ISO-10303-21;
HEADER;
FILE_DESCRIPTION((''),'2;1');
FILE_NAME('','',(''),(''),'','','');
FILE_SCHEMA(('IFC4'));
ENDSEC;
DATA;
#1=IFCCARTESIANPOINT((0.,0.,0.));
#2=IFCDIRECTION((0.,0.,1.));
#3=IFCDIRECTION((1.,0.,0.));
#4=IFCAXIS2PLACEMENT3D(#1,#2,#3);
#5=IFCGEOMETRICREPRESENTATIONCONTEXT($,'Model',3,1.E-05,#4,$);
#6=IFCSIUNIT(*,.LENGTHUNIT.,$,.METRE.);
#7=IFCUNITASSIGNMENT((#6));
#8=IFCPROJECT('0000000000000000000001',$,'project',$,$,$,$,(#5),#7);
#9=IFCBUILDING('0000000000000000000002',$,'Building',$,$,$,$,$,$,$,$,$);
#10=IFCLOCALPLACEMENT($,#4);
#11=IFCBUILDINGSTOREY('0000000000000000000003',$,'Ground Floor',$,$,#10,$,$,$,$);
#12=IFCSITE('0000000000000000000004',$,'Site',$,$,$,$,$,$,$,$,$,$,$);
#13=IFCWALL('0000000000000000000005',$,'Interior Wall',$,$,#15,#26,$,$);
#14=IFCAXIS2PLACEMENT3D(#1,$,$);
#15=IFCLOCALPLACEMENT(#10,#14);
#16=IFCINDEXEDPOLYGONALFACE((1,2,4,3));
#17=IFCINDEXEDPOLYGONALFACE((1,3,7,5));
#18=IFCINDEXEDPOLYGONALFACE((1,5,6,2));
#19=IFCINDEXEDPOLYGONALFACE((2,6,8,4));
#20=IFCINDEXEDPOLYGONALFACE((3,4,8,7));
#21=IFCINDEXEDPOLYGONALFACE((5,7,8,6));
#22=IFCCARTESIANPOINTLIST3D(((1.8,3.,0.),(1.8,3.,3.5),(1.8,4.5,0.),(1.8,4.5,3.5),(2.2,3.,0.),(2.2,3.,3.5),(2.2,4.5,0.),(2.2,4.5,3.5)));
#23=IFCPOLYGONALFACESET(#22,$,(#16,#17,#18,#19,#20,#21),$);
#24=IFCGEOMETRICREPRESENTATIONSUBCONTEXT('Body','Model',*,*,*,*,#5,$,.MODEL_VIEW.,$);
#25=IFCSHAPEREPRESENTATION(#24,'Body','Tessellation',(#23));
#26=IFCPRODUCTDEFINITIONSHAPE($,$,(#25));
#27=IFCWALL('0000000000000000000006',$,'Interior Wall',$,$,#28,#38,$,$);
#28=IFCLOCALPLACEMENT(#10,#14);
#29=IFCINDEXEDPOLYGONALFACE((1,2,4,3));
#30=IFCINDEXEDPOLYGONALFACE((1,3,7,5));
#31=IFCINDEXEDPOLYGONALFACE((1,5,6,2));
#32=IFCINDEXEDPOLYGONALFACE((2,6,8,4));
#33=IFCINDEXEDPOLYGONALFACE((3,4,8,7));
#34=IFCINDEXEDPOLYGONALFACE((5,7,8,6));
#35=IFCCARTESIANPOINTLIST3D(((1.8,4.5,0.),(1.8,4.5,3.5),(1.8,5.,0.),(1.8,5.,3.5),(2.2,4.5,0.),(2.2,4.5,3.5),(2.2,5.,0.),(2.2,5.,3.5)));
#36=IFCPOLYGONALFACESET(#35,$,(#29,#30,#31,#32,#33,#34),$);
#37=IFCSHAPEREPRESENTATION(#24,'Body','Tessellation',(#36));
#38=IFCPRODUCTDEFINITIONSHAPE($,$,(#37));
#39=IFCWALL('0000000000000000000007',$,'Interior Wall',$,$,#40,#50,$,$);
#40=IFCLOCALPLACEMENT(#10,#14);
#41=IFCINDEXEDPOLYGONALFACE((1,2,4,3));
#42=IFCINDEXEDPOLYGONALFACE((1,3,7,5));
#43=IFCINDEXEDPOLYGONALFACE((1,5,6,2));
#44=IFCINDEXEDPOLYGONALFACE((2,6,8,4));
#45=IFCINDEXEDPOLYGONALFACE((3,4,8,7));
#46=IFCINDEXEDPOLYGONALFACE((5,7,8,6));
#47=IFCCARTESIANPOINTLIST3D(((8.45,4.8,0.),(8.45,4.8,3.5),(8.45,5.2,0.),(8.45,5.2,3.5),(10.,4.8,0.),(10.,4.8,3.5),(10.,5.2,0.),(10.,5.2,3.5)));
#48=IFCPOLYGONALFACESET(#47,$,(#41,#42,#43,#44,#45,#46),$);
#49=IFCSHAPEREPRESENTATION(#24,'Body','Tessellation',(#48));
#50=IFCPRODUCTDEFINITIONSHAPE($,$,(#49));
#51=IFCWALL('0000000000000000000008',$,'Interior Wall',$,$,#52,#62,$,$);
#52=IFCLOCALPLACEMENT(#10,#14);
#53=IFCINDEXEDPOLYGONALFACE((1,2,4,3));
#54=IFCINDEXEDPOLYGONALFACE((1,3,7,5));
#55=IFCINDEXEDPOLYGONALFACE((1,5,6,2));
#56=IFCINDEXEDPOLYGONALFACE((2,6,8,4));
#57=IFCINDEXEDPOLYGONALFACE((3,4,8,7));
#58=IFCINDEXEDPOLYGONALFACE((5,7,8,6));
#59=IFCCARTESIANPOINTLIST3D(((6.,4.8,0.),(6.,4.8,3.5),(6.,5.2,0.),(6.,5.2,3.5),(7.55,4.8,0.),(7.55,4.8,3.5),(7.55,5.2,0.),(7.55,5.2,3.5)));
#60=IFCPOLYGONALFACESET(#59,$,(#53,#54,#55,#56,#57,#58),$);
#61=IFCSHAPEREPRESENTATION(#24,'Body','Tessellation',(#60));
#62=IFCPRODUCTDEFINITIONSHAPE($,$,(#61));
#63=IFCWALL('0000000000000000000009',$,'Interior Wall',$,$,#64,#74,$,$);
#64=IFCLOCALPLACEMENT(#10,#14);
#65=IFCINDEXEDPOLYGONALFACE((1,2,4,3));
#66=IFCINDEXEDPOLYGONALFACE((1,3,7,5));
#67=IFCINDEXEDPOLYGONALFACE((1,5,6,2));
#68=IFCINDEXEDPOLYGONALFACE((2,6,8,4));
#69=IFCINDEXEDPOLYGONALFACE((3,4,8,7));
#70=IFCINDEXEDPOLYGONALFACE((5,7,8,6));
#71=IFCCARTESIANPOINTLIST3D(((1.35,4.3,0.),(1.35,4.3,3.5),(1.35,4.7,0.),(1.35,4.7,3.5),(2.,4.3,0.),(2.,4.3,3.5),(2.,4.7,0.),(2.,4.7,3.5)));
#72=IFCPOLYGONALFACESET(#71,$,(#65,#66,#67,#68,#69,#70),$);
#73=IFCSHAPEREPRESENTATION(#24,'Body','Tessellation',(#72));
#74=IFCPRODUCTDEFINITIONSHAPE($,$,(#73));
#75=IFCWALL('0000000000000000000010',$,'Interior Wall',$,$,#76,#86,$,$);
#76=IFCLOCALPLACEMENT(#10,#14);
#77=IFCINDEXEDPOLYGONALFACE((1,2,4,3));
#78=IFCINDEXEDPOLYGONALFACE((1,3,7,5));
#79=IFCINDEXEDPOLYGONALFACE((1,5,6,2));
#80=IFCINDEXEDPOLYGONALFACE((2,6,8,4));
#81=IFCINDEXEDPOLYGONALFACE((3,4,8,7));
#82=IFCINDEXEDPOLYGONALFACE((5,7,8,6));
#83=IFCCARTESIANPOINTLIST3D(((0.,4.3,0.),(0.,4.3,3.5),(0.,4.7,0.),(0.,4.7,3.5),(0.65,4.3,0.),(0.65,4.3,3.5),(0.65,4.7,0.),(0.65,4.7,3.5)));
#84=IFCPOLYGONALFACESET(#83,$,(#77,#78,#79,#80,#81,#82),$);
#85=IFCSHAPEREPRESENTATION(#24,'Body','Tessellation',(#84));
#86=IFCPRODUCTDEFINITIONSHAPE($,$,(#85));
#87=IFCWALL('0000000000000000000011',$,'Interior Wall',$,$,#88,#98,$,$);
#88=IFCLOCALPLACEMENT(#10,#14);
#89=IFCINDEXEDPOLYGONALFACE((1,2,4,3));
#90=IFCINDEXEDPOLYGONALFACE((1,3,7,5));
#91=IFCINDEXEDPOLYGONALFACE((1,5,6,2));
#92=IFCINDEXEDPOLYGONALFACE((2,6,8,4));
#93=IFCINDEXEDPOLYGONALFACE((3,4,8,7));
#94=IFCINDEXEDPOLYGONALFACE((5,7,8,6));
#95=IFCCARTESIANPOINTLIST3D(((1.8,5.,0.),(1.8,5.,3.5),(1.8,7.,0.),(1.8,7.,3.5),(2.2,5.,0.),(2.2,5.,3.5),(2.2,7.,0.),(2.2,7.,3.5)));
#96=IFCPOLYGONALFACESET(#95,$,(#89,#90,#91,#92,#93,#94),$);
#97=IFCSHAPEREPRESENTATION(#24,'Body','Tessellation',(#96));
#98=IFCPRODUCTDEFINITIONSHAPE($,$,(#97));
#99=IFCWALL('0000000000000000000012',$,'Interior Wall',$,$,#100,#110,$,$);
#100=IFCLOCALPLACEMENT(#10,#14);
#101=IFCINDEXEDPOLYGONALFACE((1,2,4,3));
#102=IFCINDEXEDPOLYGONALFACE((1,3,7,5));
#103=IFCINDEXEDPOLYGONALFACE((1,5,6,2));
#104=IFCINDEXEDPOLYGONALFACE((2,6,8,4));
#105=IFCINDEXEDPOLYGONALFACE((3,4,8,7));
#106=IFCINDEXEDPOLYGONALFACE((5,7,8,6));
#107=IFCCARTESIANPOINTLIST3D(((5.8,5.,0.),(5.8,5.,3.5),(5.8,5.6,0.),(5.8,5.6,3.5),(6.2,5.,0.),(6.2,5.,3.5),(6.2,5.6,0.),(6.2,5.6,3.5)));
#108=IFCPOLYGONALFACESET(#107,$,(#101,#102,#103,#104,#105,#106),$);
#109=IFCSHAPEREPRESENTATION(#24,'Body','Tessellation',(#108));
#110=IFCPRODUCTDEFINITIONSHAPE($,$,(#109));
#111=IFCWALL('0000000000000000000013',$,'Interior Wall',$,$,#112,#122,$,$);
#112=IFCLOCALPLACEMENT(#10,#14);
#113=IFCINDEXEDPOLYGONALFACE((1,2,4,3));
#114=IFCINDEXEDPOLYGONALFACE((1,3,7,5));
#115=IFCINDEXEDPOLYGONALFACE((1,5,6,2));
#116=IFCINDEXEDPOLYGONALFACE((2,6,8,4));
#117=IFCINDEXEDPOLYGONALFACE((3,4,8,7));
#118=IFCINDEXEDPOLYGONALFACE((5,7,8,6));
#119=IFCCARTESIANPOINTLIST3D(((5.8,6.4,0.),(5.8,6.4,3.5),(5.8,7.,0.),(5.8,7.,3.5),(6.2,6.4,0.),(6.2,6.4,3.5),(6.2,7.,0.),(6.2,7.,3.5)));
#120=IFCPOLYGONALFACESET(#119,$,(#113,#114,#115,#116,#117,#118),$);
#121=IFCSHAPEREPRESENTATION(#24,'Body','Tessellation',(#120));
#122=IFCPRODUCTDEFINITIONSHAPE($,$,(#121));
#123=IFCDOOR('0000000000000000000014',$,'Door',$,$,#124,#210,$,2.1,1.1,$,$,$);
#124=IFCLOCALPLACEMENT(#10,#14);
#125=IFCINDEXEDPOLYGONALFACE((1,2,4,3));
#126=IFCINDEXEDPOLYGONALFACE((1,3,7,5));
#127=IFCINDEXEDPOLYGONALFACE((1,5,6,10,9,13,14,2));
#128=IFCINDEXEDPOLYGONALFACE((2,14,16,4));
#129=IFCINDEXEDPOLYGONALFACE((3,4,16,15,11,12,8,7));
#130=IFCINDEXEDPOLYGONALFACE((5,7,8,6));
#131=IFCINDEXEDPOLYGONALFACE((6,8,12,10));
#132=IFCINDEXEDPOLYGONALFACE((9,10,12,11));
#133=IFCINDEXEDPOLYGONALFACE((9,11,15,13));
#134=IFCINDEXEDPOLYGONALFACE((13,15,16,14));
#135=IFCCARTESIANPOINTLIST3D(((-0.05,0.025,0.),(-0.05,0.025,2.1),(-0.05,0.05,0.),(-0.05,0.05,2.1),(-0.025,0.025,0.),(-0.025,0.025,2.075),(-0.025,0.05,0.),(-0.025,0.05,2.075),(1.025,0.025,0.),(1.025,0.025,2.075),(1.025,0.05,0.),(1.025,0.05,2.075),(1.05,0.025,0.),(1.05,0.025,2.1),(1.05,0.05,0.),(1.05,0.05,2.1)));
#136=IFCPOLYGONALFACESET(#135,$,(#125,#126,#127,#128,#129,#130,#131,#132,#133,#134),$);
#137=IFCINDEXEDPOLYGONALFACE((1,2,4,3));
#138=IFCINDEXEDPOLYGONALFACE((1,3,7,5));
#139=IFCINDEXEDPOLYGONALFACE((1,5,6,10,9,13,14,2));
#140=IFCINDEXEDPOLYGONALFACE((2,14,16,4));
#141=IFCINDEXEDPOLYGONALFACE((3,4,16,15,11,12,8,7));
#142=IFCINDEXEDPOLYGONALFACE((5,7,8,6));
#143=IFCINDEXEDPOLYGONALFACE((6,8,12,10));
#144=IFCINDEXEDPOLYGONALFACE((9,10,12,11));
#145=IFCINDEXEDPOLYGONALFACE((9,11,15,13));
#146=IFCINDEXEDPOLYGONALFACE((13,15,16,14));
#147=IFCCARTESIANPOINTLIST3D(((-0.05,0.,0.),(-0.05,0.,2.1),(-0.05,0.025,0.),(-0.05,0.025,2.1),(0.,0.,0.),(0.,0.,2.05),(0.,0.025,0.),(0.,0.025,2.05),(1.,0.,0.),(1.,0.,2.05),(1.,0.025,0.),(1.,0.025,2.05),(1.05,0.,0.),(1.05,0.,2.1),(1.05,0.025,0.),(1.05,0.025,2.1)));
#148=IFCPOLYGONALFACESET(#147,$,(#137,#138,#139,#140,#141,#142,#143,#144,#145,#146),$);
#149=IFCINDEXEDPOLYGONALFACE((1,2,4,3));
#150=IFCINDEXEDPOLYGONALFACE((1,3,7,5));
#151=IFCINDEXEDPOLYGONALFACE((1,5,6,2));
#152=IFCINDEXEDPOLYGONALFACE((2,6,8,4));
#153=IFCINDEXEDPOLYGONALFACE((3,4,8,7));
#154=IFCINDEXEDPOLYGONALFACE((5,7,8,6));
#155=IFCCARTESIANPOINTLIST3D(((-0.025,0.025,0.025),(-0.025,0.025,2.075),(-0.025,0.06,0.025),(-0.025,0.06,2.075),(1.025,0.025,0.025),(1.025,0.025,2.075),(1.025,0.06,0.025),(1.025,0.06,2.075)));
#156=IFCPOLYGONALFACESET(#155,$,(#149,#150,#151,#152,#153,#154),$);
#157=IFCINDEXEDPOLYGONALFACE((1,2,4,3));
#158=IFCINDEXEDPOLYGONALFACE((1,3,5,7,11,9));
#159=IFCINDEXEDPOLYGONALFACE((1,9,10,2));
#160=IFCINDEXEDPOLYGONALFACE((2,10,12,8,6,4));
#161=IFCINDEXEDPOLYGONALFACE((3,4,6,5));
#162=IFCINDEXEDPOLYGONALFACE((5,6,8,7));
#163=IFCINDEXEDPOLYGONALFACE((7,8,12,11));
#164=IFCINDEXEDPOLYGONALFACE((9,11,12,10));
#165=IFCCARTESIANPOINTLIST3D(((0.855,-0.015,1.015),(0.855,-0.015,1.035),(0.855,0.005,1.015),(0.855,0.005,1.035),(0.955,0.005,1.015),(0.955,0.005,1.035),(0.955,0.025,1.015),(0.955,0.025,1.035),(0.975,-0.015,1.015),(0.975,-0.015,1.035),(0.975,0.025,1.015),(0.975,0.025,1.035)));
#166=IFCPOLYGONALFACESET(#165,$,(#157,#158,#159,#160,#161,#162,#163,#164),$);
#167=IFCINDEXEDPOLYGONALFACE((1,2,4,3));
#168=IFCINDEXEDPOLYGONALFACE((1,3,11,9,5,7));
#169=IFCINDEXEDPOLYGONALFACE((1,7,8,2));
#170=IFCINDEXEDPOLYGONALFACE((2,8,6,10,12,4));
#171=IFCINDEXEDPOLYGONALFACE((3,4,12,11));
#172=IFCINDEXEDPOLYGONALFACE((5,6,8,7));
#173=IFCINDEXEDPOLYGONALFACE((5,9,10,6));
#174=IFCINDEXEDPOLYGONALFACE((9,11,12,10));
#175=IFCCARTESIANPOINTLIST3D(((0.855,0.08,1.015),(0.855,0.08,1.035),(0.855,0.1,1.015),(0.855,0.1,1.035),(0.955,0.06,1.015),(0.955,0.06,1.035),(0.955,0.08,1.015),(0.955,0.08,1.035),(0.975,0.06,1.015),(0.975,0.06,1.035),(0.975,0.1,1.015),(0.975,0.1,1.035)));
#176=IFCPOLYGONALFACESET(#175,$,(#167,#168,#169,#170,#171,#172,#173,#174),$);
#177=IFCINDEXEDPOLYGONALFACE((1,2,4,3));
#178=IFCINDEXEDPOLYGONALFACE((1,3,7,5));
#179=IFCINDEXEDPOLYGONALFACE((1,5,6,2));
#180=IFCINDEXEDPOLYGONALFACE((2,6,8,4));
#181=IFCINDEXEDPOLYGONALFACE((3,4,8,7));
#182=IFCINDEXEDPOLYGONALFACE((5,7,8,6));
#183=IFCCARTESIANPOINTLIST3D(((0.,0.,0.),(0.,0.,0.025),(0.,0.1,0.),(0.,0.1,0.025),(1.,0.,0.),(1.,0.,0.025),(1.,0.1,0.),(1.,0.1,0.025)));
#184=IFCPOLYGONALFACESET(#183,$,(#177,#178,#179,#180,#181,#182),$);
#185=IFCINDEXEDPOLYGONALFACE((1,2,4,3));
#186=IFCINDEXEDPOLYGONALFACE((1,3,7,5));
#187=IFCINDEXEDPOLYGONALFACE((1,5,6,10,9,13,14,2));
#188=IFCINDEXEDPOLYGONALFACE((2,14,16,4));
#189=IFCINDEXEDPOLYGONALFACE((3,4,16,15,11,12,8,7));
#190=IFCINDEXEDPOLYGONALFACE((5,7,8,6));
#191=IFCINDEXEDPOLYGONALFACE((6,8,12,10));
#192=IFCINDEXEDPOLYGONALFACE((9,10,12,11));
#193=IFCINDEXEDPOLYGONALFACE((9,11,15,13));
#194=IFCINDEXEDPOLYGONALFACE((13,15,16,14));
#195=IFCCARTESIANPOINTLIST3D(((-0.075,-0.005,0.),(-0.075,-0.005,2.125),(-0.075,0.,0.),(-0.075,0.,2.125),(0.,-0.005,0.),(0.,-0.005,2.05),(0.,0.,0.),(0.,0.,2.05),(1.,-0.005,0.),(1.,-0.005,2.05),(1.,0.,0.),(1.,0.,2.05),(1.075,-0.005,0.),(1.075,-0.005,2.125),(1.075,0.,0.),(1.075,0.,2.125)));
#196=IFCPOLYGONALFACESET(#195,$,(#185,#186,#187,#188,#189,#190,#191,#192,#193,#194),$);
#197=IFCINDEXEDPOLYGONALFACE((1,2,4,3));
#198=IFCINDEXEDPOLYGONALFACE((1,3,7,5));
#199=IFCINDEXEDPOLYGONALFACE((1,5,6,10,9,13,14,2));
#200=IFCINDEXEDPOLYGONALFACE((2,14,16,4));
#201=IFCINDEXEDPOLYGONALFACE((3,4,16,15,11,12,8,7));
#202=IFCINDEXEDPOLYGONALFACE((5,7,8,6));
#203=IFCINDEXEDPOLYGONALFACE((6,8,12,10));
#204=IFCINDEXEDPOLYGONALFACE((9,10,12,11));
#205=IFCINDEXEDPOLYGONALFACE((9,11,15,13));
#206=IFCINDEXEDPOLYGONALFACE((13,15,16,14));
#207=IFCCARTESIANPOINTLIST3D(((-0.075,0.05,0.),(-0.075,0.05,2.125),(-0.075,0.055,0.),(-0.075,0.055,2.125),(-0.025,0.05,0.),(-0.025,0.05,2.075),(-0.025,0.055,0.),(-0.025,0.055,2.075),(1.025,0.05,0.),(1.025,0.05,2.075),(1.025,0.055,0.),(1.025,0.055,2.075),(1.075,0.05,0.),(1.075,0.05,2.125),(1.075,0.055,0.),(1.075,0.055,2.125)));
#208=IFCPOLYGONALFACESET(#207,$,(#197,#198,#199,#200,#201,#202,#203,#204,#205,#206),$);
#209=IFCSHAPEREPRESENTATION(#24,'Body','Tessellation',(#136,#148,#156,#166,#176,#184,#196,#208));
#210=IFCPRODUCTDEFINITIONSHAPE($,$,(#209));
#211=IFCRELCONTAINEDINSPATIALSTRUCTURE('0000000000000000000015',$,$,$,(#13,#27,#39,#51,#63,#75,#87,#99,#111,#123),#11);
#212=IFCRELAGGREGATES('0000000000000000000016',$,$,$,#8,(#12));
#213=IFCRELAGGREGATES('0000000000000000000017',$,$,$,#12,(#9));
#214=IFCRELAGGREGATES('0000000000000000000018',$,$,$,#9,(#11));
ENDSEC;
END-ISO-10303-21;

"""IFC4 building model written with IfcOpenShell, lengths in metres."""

from ifc_helpers import new_model, si_unit, frame, origin_with_axes, place, context, subcontext, project, spatial, line, indexed_curve, outline, extrude, element, save


model = new_model("IFC4")

# Units and contexts
model_context = context("Model", 3, precision=1e-05, world=origin_with_axes())
body_context = subcontext(model_context, "Body", "Model", "MODEL_VIEW")
ifc_project = project(units=[si_unit("LENGTHUNIT", "METRE")], contexts=[model_context])

# Site, building, storey
site = spatial("IfcSite", under=ifc_project, Name="Site")
building = spatial("IfcBuilding", under=site, Name="Building")
storey_placement = place(None, origin_with_axes())
storey = spatial("IfcBuildingStorey", under=building, at=storey_placement, Name="Ground Floor")

# Walls
wall_1_placement = place(storey_placement, frame((2.0, 4.5, 0.0), z_axis=(0.0, 0.0, 1.0), x_axis=(0.0, -1.0, 0.0)))
element("IfcWall", 1, at=wall_1_placement, inside=storey, Name="Interior Wall", context=body_context, shape_type="SweptSolid", body=[
    extrude(outline(indexed_curve([(0.0, 0.0), (0.0, 0.4), (1.5, 0.4), (1.5, 0.0), (0.0, 0.0)], self_intersect=False)), frame((0.0, -0.2, 0.0), z_axis=(0.0, 0.0, 1.0), x_axis=(1.0, 0.0, 0.0)), (0.0, 0.0, 1.0), 3.5),
])
wall_2_placement = place(storey_placement, frame((2.0, 5.0, 0.0), z_axis=(0.0, 0.0, 1.0), x_axis=(0.0, -1.0, 0.0)))
element("IfcWall", 2, at=wall_2_placement, inside=storey, Name="Interior Wall", context=body_context, shape_type="SweptSolid", body=[
    extrude(outline(indexed_curve([(0.0, 0.0), (0.0, 0.4), (0.5, 0.4), (0.5, 0.0), (0.0, 0.0)], self_intersect=False)), frame((0.0, -0.2, 0.0), z_axis=(0.0, 0.0, 1.0), x_axis=(1.0, 0.0, 0.0)), (0.0, 0.0, 1.0), 3.5),
])
wall_3_placement = place(storey_placement, frame((10.0, 5.0, 0.0), z_axis=(0.0, 0.0, 1.0), x_axis=(-1.0, 0.0, 0.0)))
element("IfcWall", 3, at=wall_3_placement, inside=storey, Name="Interior Wall", context=body_context, shape_type="SweptSolid", body=[
    extrude(outline(indexed_curve([(0.0, 0.0), (0.0, 0.4), (1.55, 0.4), (1.55, 0.0), (0.0, 0.0)], self_intersect=False)), frame((0.0, -0.2, 0.0), z_axis=(0.0, 0.0, 1.0), x_axis=(1.0, 0.0, 0.0)), (0.0, 0.0, 1.0), 3.5),
])
wall_4_placement = place(storey_placement, frame((7.55, 5.0, 0.0), z_axis=(0.0, 0.0, 1.0), x_axis=(-1.0, 0.0, 0.0)))
element("IfcWall", 4, at=wall_4_placement, inside=storey, Name="Interior Wall", context=body_context, shape_type="SweptSolid", body=[
    extrude(outline(indexed_curve([(0.0, 0.0), (0.0, 0.4), (1.55, 0.4), (1.55, 0.0), (0.0, 0.0)], self_intersect=False)), frame((0.0, -0.2, 0.0), z_axis=(0.0, 0.0, 1.0), x_axis=(1.0, 0.0, 0.0)), (0.0, 0.0, 1.0), 3.5),
])
for number, where, z_axis, x_axis, name in (
    (5, (2.0, 4.5, 0.0), (0.0, 0.0, 1.0), (-1.0, 0.0, 0.0), "Interior Wall"),
    (6, (0.65, 4.5, 0.0), (0.0, 0.0, 1.0), (-1.0, 0.0, 0.0), "Interior Wall"),
):
    element("IfcWall", number, at=place(storey_placement, frame(where, z_axis=z_axis, x_axis=x_axis)), inside=storey, Name=name, context=body_context, shape_type="SweptSolid", body=[
        extrude(outline(indexed_curve([(0.0, 0.0), (0.0, 0.4), (0.65, 0.4), (0.65, 0.0), (0.0, 0.0)], self_intersect=False)), frame((0.0, -0.2, 0.0), z_axis=(0.0, 0.0, 1.0), x_axis=(1.0, 0.0, 0.0)), (0.0, 0.0, 1.0), 3.5),
    ])
wall_5_placement = place(storey_placement, frame((2.0, 5.0, 0.0), z_axis=(0.0, 0.0, 1.0), x_axis=(0.0, 1.0, 0.0)))
element("IfcWall", 7, at=wall_5_placement, inside=storey, Name="Interior Wall", context=body_context, shape_type="SweptSolid", body=[
    extrude(outline(indexed_curve([(0.0, 0.0), (0.0, 0.4), (2.0, 0.4), (2.0, 0.0), (0.0, 0.0)], self_intersect=False)), frame((0.0, -0.2, 0.0), z_axis=(0.0, 0.0, 1.0), x_axis=(1.0, 0.0, 0.0)), (0.0, 0.0, 1.0), 3.5),
])
for number, where, z_axis, x_axis, name in (
    (8, (6.0, 5.0, 0.0), (0.0, 0.0, 1.0), (0.0, 1.0, 0.0), "Interior Wall"),
    (9, (6.0, 6.4, 0.0), (0.0, 0.0, 1.0), (0.0, 1.0, 0.0), "Interior Wall"),
):
    element("IfcWall", number, at=place(storey_placement, frame(where, z_axis=z_axis, x_axis=x_axis)), inside=storey, Name=name, context=body_context, shape_type="SweptSolid", body=[
        extrude(outline(indexed_curve([(0.0, 0.0), (0.0, 0.4), (0.6, 0.4), (0.6, 0.0), (0.0, 0.0)], self_intersect=False)), frame((0.0, -0.2, 0.0), z_axis=(0.0, 0.0, 1.0), x_axis=(1.0, 0.0, 0.0)), (0.0, 0.0, 1.0), 3.5),
    ])

# Door
door_1_placement = place(storey_placement, frame((-0.05, 0.0, 0.0), z_axis=(0.0, 0.0, 1.0), x_axis=(1.0, 0.0, 0.0)))
element("IfcDoor", 10, at=door_1_placement, inside=storey, Name="Door", OverallHeight=2.1, OverallWidth=1.1, context=body_context, shape_type="SweptSolid", body=[
    extrude(outline(indexed_curve([(0.0, 0.0), (0.0, 2.1), (1.1, 2.1), (1.1, 0.0), (1.075, 0.0), (1.075, 2.075), (0.025, 2.075), (0.025, 0.0)], segments=[line(1, 2, 3, 4, 5, 6, 7, 8, 1)])), frame((0.0, 0.025, 0.0), z_axis=(0.0, -1.0, 0.0), x_axis=(1.0, 0.0, 0.0)), (0.0, 0.0, -1.0), 0.025),
    extrude(outline(indexed_curve([(0.0, 0.0), (0.0, 2.1), (1.1, 2.1), (1.1, 0.0), (1.05, 0.0), (1.05, 2.05), (0.05, 2.05), (0.05, 0.0)], segments=[line(1, 2, 3, 4, 5, 6, 7, 8, 1)])), frame((0.0, 0.0, 0.0), z_axis=(0.0, -1.0, 0.0), x_axis=(1.0, 0.0, 0.0)), (0.0, 0.0, -1.0), 0.025),
    extrude(outline(indexed_curve([(0.0, 0.0), (1.05, 0.0), (1.05, 0.035), (0.0, 0.035)], segments=[line(1, 2, 3, 4, 1)])), frame((0.025, 0.025, 0.025), z_axis=(0.0, 0.0, 1.0), x_axis=(1.0, 0.0, 0.0)), (0.0, 0.0, 1.0), 2.05),
    extrude(outline(indexed_curve([(0.0, 0.0), (0.0, -0.04), (-0.12, -0.04), (-0.12, -0.02), (-0.02, -0.02), (-0.02, 0.0)], segments=[line(1, 2, 3, 4, 5, 6, 1)])), frame((1.025, 0.025, 1.015), z_axis=(0.0, 0.0, 1.0), x_axis=(1.0, 0.0, 0.0)), (0.0, 0.0, 1.0), 0.02),
    extrude(outline(indexed_curve([(0.0, 0.0), (0.0, 0.04), (-0.12, 0.04), (-0.12, 0.02), (-0.02, 0.02), (-0.02, 0.0)], segments=[line(1, 2, 3, 4, 5, 6, 1)])), frame((1.025, 0.06, 1.015), z_axis=(0.0, 0.0, 1.0), x_axis=(1.0, 0.0, 0.0)), (0.0, 0.0, 1.0), 0.02),
    extrude(outline(indexed_curve([(0.0, 0.0), (1.0, 0.0), (1.0, 0.1), (0.0, 0.1)], segments=[line(1, 2, 3, 4, 1)])), frame((0.05, 0.0, 0.0), z_axis=(0.0, 0.0, 1.0), x_axis=(1.0, 0.0, 0.0)), (0.0, 0.0, 1.0), 0.025),
    extrude(outline(indexed_curve([(0.0, 0.0), (0.0, 2.125), (1.15, 2.125), (1.15, 0.0), (1.075, 0.0), (1.075, 2.05), (0.075, 2.05), (0.075, 0.0)], segments=[line(1, 2, 3, 4, 5, 6, 7, 8, 1)])), frame((-0.025, -0.005, 0.0), z_axis=(0.0, -1.0, 0.0), x_axis=(1.0, 0.0, 0.0)), (0.0, 0.0, -1.0), 0.005),
    extrude(outline(indexed_curve([(0.0, 0.0), (0.0, 2.125), (1.15, 2.125), (1.15, 0.0), (1.1, 0.0), (1.1, 2.075), (0.05, 2.075), (0.05, 0.0)], segments=[line(1, 2, 3, 4, 5, 6, 7, 8, 1)])), frame((-0.025, 0.05, 0.0), z_axis=(0.0, -1.0, 0.0), x_axis=(1.0, 0.0, 0.0)), (0.0, 0.0, -1.0), 0.005),
])

save(model, "model.ifc")
